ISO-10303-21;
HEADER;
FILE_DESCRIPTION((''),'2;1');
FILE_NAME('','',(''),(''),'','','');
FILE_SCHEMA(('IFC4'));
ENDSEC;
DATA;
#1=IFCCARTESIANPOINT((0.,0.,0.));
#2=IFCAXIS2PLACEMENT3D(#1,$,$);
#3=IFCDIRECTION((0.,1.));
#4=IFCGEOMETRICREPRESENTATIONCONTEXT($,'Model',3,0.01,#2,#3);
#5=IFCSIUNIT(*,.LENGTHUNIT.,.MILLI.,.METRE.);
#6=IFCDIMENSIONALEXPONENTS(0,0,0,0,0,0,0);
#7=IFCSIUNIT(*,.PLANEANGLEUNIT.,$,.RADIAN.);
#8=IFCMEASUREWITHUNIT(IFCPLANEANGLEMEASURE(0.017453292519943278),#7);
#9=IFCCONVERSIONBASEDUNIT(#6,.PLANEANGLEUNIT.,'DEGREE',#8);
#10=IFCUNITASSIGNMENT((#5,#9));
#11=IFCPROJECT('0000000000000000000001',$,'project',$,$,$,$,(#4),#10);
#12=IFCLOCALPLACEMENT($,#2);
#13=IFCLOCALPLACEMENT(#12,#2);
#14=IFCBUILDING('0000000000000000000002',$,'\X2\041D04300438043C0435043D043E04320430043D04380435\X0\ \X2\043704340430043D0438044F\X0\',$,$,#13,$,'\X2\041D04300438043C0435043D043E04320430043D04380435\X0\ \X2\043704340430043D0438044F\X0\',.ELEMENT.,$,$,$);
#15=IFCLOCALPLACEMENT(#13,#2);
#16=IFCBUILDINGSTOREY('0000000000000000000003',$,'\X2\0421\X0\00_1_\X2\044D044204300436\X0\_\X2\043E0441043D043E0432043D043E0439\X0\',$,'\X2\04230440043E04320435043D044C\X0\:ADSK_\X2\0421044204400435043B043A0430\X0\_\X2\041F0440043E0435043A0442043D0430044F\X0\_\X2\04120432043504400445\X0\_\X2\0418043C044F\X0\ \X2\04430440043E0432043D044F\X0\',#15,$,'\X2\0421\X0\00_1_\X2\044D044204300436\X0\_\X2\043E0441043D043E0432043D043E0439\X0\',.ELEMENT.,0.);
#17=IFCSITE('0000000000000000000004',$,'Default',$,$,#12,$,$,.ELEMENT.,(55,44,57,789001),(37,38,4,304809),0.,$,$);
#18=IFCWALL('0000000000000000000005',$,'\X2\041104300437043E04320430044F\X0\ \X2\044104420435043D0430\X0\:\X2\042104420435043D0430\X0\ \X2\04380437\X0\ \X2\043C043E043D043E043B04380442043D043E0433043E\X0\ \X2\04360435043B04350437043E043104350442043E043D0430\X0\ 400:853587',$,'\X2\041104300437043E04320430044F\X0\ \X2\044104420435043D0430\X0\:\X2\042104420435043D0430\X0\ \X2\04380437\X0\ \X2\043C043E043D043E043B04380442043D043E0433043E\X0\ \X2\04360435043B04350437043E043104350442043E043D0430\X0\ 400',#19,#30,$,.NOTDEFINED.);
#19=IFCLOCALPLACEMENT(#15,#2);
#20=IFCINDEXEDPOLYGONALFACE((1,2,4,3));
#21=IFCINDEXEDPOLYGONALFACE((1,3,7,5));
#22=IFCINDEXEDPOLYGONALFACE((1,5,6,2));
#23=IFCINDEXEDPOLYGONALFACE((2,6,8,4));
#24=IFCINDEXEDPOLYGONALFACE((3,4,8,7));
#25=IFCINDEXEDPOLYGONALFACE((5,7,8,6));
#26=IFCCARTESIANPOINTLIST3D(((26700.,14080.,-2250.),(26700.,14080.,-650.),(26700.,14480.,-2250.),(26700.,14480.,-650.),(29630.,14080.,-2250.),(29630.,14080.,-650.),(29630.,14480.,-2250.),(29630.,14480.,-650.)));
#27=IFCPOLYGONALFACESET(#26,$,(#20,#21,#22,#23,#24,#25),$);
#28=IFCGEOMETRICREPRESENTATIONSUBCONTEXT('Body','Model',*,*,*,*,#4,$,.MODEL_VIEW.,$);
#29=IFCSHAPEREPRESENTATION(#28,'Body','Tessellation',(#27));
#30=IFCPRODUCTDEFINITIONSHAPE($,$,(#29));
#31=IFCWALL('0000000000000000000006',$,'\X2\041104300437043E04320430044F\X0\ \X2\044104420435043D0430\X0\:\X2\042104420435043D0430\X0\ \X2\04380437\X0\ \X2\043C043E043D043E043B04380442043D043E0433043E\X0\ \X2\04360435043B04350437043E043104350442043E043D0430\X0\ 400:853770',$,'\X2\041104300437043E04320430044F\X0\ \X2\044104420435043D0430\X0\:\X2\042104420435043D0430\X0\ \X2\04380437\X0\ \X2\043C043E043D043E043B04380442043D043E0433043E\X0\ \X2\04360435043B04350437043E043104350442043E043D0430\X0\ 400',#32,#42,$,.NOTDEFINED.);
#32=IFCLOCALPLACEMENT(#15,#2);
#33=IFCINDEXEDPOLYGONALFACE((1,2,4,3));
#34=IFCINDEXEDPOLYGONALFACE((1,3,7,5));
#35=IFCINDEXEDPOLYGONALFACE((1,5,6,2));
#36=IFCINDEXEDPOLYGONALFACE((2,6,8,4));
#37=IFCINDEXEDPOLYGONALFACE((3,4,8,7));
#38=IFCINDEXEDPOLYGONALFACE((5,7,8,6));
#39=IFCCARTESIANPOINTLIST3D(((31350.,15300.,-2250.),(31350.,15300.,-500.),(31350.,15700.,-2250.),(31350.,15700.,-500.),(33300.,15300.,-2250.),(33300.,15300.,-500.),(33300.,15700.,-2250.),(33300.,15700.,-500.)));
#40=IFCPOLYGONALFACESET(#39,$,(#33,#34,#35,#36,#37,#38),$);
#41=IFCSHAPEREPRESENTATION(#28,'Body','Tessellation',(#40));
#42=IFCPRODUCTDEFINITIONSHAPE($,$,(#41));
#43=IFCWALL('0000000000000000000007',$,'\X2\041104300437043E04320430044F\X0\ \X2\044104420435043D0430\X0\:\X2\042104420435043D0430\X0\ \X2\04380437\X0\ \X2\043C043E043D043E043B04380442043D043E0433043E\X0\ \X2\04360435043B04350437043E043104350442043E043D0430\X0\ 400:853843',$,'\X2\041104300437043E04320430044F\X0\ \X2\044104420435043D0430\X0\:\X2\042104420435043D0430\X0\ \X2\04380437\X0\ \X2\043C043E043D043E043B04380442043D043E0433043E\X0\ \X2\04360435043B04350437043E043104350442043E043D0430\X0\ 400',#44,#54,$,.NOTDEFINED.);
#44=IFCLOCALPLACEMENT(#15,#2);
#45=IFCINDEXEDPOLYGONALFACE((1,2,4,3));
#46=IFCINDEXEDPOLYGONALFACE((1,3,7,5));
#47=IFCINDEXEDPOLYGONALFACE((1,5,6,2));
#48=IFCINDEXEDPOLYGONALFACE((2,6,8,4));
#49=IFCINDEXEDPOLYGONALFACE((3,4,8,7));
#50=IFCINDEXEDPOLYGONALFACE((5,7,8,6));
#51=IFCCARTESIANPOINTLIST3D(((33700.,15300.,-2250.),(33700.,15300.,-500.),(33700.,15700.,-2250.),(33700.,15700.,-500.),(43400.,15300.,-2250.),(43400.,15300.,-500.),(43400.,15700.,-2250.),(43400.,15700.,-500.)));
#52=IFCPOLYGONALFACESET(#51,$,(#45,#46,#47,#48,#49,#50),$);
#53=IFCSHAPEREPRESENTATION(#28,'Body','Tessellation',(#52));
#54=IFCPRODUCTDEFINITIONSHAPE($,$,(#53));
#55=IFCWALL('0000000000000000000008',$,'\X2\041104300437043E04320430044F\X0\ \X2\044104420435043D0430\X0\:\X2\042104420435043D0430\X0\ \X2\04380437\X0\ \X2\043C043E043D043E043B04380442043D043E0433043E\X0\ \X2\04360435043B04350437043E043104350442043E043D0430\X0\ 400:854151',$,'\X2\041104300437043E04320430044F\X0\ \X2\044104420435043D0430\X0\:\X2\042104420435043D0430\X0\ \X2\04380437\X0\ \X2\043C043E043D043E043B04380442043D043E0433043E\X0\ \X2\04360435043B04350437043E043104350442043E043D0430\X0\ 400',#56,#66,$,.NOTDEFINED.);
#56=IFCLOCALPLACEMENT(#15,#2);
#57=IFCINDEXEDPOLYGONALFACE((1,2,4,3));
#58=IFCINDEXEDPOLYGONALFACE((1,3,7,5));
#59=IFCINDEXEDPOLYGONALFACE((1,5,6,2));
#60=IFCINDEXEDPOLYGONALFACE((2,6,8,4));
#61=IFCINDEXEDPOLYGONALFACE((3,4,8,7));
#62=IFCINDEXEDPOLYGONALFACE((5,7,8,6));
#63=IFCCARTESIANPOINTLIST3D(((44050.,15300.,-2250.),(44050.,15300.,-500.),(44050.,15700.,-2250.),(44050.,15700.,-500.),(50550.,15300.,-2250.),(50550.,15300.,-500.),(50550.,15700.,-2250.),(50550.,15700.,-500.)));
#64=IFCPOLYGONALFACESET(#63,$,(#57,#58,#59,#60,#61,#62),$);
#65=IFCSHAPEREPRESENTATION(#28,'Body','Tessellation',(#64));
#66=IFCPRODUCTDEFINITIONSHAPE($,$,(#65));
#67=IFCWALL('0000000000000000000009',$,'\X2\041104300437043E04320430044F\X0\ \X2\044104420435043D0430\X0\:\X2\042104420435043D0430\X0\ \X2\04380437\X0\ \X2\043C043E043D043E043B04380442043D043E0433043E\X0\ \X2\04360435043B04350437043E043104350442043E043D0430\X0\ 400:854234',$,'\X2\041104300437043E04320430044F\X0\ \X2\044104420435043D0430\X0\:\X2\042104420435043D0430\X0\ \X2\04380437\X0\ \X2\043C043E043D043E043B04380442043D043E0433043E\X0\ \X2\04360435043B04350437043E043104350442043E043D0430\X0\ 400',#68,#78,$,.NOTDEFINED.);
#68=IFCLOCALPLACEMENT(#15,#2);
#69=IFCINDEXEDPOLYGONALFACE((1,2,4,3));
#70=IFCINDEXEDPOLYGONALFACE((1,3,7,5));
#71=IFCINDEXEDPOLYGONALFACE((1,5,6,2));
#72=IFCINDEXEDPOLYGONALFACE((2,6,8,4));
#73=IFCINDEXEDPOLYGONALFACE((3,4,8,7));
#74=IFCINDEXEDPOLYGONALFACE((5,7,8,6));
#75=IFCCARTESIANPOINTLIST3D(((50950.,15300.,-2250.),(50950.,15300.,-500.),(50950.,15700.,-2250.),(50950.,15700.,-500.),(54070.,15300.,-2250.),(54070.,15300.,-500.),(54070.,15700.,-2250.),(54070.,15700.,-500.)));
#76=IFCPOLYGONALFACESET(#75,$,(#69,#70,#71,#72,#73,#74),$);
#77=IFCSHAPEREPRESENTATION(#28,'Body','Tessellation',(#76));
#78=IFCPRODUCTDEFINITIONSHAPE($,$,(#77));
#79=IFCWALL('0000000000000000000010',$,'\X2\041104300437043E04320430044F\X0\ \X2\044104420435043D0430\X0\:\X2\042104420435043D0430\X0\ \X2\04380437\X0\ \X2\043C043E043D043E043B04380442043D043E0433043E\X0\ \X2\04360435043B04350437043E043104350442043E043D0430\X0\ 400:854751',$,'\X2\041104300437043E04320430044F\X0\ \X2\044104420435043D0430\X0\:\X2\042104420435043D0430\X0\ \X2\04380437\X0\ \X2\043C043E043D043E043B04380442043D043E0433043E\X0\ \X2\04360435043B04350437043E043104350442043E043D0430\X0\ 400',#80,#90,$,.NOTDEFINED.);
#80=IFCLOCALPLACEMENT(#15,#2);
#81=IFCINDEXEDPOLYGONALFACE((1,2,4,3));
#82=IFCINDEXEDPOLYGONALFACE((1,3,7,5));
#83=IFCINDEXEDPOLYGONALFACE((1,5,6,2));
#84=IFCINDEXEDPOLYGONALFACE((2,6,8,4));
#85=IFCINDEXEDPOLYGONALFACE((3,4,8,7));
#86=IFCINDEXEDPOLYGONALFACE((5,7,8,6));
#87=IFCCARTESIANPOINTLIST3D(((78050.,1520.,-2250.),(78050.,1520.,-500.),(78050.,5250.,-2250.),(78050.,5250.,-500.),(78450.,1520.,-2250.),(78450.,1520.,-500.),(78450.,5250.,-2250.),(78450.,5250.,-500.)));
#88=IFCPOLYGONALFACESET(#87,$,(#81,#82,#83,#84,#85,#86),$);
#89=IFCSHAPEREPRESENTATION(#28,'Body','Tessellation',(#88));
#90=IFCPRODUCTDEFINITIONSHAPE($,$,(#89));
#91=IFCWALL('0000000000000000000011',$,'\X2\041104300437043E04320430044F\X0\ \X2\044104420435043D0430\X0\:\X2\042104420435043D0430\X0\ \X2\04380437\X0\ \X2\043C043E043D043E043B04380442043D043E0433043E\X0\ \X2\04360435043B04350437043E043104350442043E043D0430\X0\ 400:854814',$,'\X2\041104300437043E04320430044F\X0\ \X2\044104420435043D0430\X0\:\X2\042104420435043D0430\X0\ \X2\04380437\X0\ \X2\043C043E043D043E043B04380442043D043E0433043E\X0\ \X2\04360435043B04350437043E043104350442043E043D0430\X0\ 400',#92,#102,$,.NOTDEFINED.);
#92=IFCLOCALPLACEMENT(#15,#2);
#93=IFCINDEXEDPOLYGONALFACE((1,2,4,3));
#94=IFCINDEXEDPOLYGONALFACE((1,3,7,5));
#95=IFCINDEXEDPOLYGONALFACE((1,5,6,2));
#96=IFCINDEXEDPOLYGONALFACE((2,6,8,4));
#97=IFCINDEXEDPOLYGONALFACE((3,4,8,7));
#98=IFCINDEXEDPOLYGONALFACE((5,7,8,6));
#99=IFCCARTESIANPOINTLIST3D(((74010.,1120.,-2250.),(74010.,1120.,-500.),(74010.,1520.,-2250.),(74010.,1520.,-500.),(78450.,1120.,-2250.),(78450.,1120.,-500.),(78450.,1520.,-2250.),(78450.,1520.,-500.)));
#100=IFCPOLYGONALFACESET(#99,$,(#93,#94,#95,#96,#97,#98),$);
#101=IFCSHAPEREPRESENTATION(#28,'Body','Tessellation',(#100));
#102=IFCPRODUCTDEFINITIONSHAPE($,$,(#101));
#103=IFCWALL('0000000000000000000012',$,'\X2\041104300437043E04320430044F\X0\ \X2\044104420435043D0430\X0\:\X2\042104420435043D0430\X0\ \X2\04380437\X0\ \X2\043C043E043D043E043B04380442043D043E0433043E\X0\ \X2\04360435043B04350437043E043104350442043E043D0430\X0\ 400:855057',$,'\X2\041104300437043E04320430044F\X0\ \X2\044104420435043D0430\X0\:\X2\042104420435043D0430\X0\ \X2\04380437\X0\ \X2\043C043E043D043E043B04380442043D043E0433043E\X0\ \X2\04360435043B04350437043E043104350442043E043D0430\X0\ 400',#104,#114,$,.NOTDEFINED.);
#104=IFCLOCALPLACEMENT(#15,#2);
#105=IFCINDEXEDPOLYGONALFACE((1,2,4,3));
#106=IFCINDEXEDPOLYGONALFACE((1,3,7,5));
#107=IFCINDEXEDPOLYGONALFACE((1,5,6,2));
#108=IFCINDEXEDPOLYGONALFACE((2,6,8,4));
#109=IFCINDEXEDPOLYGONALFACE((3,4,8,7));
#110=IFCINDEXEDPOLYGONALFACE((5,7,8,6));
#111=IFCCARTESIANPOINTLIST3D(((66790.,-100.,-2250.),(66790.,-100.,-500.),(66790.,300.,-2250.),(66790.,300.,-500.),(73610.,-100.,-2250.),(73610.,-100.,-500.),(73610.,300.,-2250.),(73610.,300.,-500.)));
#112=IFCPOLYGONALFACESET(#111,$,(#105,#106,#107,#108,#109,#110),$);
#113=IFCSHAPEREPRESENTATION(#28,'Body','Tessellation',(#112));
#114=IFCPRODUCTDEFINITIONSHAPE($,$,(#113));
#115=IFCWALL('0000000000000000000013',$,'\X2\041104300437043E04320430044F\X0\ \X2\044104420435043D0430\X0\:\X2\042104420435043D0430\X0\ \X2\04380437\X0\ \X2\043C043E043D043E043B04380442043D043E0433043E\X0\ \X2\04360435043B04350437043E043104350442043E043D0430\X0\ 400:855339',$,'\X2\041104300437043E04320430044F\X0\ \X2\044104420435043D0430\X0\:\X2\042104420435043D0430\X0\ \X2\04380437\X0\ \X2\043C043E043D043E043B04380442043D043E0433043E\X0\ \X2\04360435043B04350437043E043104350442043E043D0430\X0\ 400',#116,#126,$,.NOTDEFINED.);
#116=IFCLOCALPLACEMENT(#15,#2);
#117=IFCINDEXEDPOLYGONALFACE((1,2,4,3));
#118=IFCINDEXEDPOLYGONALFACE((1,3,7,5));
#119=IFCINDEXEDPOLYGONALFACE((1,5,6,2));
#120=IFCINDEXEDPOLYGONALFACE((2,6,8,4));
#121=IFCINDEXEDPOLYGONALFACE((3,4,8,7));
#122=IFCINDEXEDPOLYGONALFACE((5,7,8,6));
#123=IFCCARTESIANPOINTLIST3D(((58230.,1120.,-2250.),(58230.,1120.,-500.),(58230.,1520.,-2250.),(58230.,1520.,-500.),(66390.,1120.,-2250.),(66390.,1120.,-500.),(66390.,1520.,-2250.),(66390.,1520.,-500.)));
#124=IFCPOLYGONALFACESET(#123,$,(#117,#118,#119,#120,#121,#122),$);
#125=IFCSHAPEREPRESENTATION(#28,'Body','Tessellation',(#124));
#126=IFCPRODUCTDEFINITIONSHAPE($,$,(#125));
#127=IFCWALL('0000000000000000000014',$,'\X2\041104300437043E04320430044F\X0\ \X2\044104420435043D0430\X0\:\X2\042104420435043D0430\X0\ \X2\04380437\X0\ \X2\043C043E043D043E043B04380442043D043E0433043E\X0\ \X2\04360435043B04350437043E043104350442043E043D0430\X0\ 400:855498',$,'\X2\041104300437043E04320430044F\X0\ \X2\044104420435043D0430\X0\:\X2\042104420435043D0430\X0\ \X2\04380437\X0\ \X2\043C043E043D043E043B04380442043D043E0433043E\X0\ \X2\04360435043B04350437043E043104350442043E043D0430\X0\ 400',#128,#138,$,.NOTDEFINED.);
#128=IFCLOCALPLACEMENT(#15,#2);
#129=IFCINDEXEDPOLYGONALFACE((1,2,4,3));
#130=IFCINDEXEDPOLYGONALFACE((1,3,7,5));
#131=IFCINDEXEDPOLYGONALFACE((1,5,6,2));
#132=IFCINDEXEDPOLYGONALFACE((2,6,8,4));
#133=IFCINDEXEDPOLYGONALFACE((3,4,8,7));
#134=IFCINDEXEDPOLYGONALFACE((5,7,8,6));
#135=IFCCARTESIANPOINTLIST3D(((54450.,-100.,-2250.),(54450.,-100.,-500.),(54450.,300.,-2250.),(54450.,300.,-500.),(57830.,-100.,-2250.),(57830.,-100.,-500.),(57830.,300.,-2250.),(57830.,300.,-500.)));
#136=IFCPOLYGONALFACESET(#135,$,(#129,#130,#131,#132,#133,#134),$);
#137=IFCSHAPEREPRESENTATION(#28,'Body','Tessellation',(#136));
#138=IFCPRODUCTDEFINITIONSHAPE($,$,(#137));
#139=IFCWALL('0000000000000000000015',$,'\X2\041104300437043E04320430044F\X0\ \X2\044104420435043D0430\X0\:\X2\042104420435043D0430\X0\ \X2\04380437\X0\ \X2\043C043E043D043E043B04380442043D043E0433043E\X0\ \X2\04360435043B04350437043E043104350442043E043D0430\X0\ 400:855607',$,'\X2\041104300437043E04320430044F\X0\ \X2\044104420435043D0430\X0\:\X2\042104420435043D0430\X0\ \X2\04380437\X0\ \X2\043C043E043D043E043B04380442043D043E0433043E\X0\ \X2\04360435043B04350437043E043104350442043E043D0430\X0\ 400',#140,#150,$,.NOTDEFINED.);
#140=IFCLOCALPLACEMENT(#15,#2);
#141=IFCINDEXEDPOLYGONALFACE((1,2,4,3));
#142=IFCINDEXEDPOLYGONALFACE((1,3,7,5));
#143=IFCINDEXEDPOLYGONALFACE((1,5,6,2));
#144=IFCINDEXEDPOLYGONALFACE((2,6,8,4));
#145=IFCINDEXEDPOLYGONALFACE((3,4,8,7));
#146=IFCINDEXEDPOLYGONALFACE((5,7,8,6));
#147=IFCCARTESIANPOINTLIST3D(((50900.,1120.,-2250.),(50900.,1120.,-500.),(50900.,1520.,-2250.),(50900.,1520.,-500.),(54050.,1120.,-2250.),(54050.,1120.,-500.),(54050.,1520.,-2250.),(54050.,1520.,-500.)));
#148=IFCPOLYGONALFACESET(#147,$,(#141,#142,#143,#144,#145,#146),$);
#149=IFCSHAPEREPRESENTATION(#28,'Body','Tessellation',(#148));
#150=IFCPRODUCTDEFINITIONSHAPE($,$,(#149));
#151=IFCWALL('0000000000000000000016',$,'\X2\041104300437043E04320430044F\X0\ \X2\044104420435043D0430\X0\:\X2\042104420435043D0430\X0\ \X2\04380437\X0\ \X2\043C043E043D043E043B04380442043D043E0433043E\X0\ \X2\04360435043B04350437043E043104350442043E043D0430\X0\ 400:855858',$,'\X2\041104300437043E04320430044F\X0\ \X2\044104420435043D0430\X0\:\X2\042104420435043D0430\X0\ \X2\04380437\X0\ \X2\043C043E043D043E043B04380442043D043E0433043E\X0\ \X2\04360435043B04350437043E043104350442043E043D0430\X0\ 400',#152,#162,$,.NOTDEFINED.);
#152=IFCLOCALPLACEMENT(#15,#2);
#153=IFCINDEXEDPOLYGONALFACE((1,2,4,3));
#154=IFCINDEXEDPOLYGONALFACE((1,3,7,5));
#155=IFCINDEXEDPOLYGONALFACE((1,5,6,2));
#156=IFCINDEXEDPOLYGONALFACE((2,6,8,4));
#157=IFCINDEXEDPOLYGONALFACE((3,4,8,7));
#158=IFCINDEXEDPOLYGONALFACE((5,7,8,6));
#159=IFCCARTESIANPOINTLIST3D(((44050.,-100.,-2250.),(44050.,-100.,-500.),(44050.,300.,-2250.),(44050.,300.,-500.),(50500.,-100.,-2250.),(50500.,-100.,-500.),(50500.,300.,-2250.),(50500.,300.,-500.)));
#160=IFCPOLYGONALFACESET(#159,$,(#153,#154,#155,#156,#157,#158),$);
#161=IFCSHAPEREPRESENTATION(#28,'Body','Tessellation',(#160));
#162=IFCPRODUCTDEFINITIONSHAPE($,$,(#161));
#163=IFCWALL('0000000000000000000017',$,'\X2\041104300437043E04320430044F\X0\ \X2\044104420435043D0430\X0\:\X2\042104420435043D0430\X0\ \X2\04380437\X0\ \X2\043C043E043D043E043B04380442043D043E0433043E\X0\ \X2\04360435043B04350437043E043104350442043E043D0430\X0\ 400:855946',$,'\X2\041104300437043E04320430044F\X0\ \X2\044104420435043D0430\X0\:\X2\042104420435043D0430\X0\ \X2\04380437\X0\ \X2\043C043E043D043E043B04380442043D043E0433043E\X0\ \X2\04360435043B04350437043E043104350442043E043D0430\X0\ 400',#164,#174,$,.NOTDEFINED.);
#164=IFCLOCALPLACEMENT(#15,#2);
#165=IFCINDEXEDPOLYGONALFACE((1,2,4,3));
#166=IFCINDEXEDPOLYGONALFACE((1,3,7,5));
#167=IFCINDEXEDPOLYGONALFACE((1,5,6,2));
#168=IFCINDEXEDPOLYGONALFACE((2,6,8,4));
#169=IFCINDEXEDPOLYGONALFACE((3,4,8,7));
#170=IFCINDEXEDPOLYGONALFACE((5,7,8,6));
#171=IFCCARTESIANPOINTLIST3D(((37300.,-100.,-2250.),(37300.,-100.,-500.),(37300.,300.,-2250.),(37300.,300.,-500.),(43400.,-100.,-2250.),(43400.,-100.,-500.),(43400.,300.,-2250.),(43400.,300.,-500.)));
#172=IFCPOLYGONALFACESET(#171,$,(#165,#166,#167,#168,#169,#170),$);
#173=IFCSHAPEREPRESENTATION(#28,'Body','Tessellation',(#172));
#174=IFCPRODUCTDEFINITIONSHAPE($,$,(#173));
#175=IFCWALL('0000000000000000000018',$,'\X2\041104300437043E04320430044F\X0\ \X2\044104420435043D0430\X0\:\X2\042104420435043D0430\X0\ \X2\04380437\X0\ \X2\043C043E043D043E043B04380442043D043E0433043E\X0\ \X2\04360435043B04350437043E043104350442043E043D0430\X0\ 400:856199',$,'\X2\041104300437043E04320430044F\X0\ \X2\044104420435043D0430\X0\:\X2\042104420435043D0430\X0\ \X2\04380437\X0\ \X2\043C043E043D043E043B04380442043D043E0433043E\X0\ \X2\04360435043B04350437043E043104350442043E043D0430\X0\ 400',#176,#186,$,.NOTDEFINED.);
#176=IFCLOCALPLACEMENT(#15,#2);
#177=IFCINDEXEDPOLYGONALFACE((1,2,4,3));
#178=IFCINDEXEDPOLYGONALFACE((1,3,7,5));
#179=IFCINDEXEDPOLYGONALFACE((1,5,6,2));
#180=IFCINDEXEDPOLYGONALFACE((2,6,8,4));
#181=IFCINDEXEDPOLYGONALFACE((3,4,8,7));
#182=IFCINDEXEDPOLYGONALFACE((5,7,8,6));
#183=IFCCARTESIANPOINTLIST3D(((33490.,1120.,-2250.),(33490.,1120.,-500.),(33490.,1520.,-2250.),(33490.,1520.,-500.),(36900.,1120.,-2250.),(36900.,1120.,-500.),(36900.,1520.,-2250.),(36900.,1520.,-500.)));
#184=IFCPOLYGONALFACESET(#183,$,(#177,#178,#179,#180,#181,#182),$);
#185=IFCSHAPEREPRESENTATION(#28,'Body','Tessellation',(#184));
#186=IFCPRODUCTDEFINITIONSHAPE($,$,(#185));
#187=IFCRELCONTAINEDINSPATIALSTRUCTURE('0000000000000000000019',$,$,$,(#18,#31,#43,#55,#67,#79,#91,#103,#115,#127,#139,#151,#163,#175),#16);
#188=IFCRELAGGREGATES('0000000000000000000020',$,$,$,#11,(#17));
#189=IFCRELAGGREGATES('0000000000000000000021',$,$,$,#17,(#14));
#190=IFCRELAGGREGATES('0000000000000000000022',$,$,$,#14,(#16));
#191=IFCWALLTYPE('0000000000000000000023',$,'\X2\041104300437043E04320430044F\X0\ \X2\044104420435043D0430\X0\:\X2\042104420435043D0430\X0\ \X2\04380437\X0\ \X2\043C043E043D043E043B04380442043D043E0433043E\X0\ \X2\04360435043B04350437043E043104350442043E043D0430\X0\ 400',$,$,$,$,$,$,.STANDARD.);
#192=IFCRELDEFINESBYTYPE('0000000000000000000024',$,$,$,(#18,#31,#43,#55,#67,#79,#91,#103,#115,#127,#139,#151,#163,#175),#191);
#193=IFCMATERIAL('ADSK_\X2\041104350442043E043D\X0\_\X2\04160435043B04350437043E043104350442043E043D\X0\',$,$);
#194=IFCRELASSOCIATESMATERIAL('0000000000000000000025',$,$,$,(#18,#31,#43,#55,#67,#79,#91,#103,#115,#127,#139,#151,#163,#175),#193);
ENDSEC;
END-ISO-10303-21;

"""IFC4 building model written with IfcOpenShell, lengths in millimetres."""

from ifc_helpers import new_model, entity, si_unit, converted_unit, direction, frame, origin, place, context, subcontext, project, spatial, indexed_curve, outline, extrude, material, type_object, element, save


model = new_model("IFC4")

# Units and contexts
model_context = context("Model", 3, precision=0.01, world=origin(), true_north=direction((0.0, 1.0)))
body_context = subcontext(model_context, "Body", "Model", "MODEL_VIEW")
ifc_project = project(units=[si_unit("LENGTHUNIT", "METRE", prefix="MILLI"), converted_unit("PLANEANGLEUNIT", "DEGREE", entity("IfcPlaneAngleMeasure", 0.017453292519943278), si_unit("PLANEANGLEUNIT", "RADIAN"), dimensions=[0, 0, 0, 0, 0, 0, 0])], contexts=[model_context])

# Site, building, storey
site_placement = place(None, origin())
site = spatial("IfcSite", under=ifc_project, at=site_placement, Name="Default", CompositionType="ELEMENT", RefLatitude=(55, 44, 57, 789001), RefLongitude=(37, 38, 4, 304809), RefElevation=0.0)
building_placement = place(site_placement, origin())
building = spatial("IfcBuilding", under=site, at=building_placement, Name="Наименование здания", LongName="Наименование здания", CompositionType="ELEMENT")
storey_placement = place(building_placement, origin())
storey = spatial("IfcBuildingStorey", under=building, at=storey_placement, Name="С00_1_этаж_основной", ObjectType="Уровень:ADSK_Стрелка_Проектная_Вверх_Имя уровня", LongName="С00_1_этаж_основной", CompositionType="ELEMENT", Elevation=0.0)

# Walls
ifc_material_1 = material(Name="ADSK_Бетон_Железобетон")
wall_type_1 = type_object("IfcWallType", Name="Базовая стена:Стена из монолитного железобетона 400", PredefinedType="STANDARD")
wall_1_placement = place(storey_placement, frame((29630.0, 14280.0, -2250.0), z_axis=(0.0, 0.0, 1.0), x_axis=(-1.0, 0.0, 0.0)))
element("IfcWall", 1, at=wall_1_placement, inside=storey, type_object=wall_type_1, material=ifc_material_1, Name="Базовая стена:Стена из монолитного железобетона 400:853587", ObjectType="Базовая стена:Стена из монолитного железобетона 400", PredefinedType="NOTDEFINED", context=body_context, shape_type="SweptSolid", body=[
    extrude(outline(indexed_curve([(2930.0, 200.0), (0.0, 200.0), (0.0, -200.0), (2930.0, -200.0), (2930.0, 200.0)], self_intersect=False)), origin(), (0.0, 0.0, 1.0), 1600.0),
])
wall_2_placement = place(storey_placement, frame((31350.0, 15500.0, -2250.0)))
element("IfcWall", 2, at=wall_2_placement, inside=storey, type_object=wall_type_1, material=ifc_material_1, Name="Базовая стена:Стена из монолитного железобетона 400:853770", ObjectType="Базовая стена:Стена из монолитного железобетона 400", PredefinedType="NOTDEFINED", context=body_context, shape_type="SweptSolid", body=[
    extrude(outline(indexed_curve([(1950.0, 200.0), (0.0, 200.0), (0.0, -200.0), (1950.0, -200.0), (1950.0, 200.0)], self_intersect=False)), origin(), (0.0, 0.0, 1.0), 1750.0),
])
wall_3_placement = place(storey_placement, frame((33700.0, 15500.0, -2250.0)))
element("IfcWall", 3, at=wall_3_placement, inside=storey, type_object=wall_type_1, material=ifc_material_1, Name="Базовая стена:Стена из монолитного железобетона 400:853843", ObjectType="Базовая стена:Стена из монолитного железобетона 400", PredefinedType="NOTDEFINED", context=body_context, shape_type="SweptSolid", body=[
    extrude(outline(indexed_curve([(9700.0, 200.0), (0.0, 200.0), (0.0, -200.0), (9700.0, -200.0), (9700.0, 200.0)], self_intersect=False)), origin(), (0.0, 0.0, 1.0), 1750.0),
])
wall_4_placement = place(storey_placement, frame((44050.0, 15500.0, -2250.0)))
element("IfcWall", 4, at=wall_4_placement, inside=storey, type_object=wall_type_1, material=ifc_material_1, Name="Базовая стена:Стена из монолитного железобетона 400:854151", ObjectType="Базовая стена:Стена из монолитного железобетона 400", PredefinedType="NOTDEFINED", context=body_context, shape_type="SweptSolid", body=[
    extrude(outline(indexed_curve([(6500.0, 200.0), (0.0, 200.0), (0.0, -200.0), (6500.0, -200.0), (6500.0, 200.0)], self_intersect=False)), origin(), (0.0, 0.0, 1.0), 1750.0),
])
wall_5_placement = place(storey_placement, frame((50950.0, 15500.0, -2250.0)))
element("IfcWall", 5, at=wall_5_placement, inside=storey, type_object=wall_type_1, material=ifc_material_1, Name="Базовая стена:Стена из монолитного железобетона 400:854234", ObjectType="Базовая стена:Стена из монолитного железобетона 400", PredefinedType="NOTDEFINED", context=body_context, shape_type="SweptSolid", body=[
    extrude(outline(indexed_curve([(3120.0, 200.0), (0.0, 200.0), (0.0, -200.0), (3120.0, -200.0), (3120.0, 200.0)], self_intersect=False)), origin(), (0.0, 0.0, 1.0), 1750.0),
])
wall_6_placement = place(storey_placement, frame((78250.0, 5250.0, -2250.0), z_axis=(0.0, 0.0, 1.0), x_axis=(0.0, -1.0, 0.0)))
element("IfcWall", 6, at=wall_6_placement, inside=storey, type_object=wall_type_1, material=ifc_material_1, Name="Базовая стена:Стена из монолитного железобетона 400:854751", ObjectType="Базовая стена:Стена из монолитного железобетона 400", PredefinedType="NOTDEFINED", context=body_context, shape_type="SweptSolid", body=[
    extrude(outline(indexed_curve([(3730.0, 200.0), (0.0, 200.0), (0.0, -200.0), (3730.0, -200.0), (3730.0, 200.0)], self_intersect=False)), origin(), (0.0, 0.0, 1.0), 1750.0),
])
wall_7_placement = place(storey_placement, frame((78450.0, 1320.0, -2250.0), z_axis=(0.0, 0.0, 1.0), x_axis=(-1.0, 0.0, 0.0)))
element("IfcWall", 7, at=wall_7_placement, inside=storey, type_object=wall_type_1, material=ifc_material_1, Name="Базовая стена:Стена из монолитного железобетона 400:854814", ObjectType="Базовая стена:Стена из монолитного железобетона 400", PredefinedType="NOTDEFINED", context=body_context, shape_type="SweptSolid", body=[
    extrude(outline(indexed_curve([(4440.0, 200.0), (0.0, 200.0), (0.0, -200.0), (4440.0, -200.0), (4440.0, 200.0)], self_intersect=False)), origin(), (0.0, 0.0, 1.0), 1750.0),
])
wall_8_placement = place(storey_placement, frame((73610.0, 100.0, -2250.0), z_axis=(0.0, 0.0, 1.0), x_axis=(-1.0, 0.0, 0.0)))
element("IfcWall", 8, at=wall_8_placement, inside=storey, type_object=wall_type_1, material=ifc_material_1, Name="Базовая стена:Стена из монолитного железобетона 400:855057", ObjectType="Базовая стена:Стена из монолитного железобетона 400", PredefinedType="NOTDEFINED", context=body_context, shape_type="SweptSolid", body=[
    extrude(outline(indexed_curve([(6820.0, 200.0), (0.0, 200.0), (0.0, -200.0), (6820.0, -200.0), (6820.0, 200.0)], self_intersect=False)), origin(), (0.0, 0.0, 1.0), 1750.0),
])
wall_9_placement = place(storey_placement, frame((66390.0, 1320.0, -2250.0), z_axis=(0.0, 0.0, 1.0), x_axis=(-1.0, 0.0, 0.0)))
element("IfcWall", 9, at=wall_9_placement, inside=storey, type_object=wall_type_1, material=ifc_material_1, Name="Базовая стена:Стена из монолитного железобетона 400:855339", ObjectType="Базовая стена:Стена из монолитного железобетона 400", PredefinedType="NOTDEFINED", context=body_context, shape_type="SweptSolid", body=[
    extrude(outline(indexed_curve([(8160.0, 200.0), (0.0, 200.0), (0.0, -200.0), (8160.0, -200.0), (8160.0, 200.0)], self_intersect=False)), origin(), (0.0, 0.0, 1.0), 1750.0),
])
wall_10_placement = place(storey_placement, frame((57830.0, 100.0, -2250.0), z_axis=(0.0, 0.0, 1.0), x_axis=(-1.0, 0.0, 0.0)))
element("IfcWall", 10, at=wall_10_placement, inside=storey, type_object=wall_type_1, material=ifc_material_1, Name="Базовая стена:Стена из монолитного железобетона 400:855498", ObjectType="Базовая стена:Стена из монолитного железобетона 400", PredefinedType="NOTDEFINED", context=body_context, shape_type="SweptSolid", body=[
    extrude(outline(indexed_curve([(3380.0, 200.0), (0.0, 200.0), (0.0, -200.0), (3380.0, -200.0), (3380.0, 200.0)], self_intersect=False)), origin(), (0.0, 0.0, 1.0), 1750.0),
])
wall_11_placement = place(storey_placement, frame((54050.0, 1320.0, -2250.0), z_axis=(0.0, 0.0, 1.0), x_axis=(-1.0, 0.0, 0.0)))
element("IfcWall", 11, at=wall_11_placement, inside=storey, type_object=wall_type_1, material=ifc_material_1, Name="Базовая стена:Стена из монолитного железобетона 400:855607", ObjectType="Базовая стена:Стена из монолитного железобетона 400", PredefinedType="NOTDEFINED", context=body_context, shape_type="SweptSolid", body=[
    extrude(outline(indexed_curve([(3150.0, 200.0), (0.0, 200.0), (0.0, -200.0), (3150.0, -200.0), (3150.0, 200.0)], self_intersect=False)), origin(), (0.0, 0.0, 1.0), 1750.0),
])
wall_12_placement = place(storey_placement, frame((50500.0, 100.0, -2250.0), z_axis=(0.0, 0.0, 1.0), x_axis=(-1.0, 0.0, 0.0)))
element("IfcWall", 12, at=wall_12_placement, inside=storey, type_object=wall_type_1, material=ifc_material_1, Name="Базовая стена:Стена из монолитного железобетона 400:855858", ObjectType="Базовая стена:Стена из монолитного железобетона 400", PredefinedType="NOTDEFINED", context=body_context, shape_type="SweptSolid", body=[
    extrude(outline(indexed_curve([(6450.0, 200.0), (0.0, 200.0), (0.0, -200.0), (6450.0, -200.0), (6450.0, 200.0)], self_intersect=False)), origin(), (0.0, 0.0, 1.0), 1750.0),
])
wall_13_placement = place(storey_placement, frame((43400.0, 100.0, -2250.0), z_axis=(0.0, 0.0, 1.0), x_axis=(-1.0, 0.0, 0.0)))
element("IfcWall", 13, at=wall_13_placement, inside=storey, type_object=wall_type_1, material=ifc_material_1, Name="Базовая стена:Стена из монолитного железобетона 400:855946", ObjectType="Базовая стена:Стена из монолитного железобетона 400", PredefinedType="NOTDEFINED", context=body_context, shape_type="SweptSolid", body=[
    extrude(outline(indexed_curve([(6100.0, 200.0), (0.0, 200.0), (0.0, -200.0), (6100.0, -200.0), (6100.0, 200.0)], self_intersect=False)), origin(), (0.0, 0.0, 1.0), 1750.0),
])
wall_14_placement = place(storey_placement, frame((36900.0, 1320.0, -2250.0), z_axis=(0.0, 0.0, 1.0), x_axis=(-1.0, 0.0, 0.0)))
element("IfcWall", 14, at=wall_14_placement, inside=storey, type_object=wall_type_1, material=ifc_material_1, Name="Базовая стена:Стена из монолитного железобетона 400:856199", ObjectType="Базовая стена:Стена из монолитного железобетона 400", PredefinedType="NOTDEFINED", context=body_context, shape_type="SweptSolid", body=[
    extrude(outline(indexed_curve([(3410.0, 200.0), (0.0, 200.0), (0.0, -200.0), (3410.0, -200.0), (3410.0, 200.0)], self_intersect=False)), origin(), (0.0, 0.0, 1.0), 1750.0),
])

save(model, "model.ifc")
